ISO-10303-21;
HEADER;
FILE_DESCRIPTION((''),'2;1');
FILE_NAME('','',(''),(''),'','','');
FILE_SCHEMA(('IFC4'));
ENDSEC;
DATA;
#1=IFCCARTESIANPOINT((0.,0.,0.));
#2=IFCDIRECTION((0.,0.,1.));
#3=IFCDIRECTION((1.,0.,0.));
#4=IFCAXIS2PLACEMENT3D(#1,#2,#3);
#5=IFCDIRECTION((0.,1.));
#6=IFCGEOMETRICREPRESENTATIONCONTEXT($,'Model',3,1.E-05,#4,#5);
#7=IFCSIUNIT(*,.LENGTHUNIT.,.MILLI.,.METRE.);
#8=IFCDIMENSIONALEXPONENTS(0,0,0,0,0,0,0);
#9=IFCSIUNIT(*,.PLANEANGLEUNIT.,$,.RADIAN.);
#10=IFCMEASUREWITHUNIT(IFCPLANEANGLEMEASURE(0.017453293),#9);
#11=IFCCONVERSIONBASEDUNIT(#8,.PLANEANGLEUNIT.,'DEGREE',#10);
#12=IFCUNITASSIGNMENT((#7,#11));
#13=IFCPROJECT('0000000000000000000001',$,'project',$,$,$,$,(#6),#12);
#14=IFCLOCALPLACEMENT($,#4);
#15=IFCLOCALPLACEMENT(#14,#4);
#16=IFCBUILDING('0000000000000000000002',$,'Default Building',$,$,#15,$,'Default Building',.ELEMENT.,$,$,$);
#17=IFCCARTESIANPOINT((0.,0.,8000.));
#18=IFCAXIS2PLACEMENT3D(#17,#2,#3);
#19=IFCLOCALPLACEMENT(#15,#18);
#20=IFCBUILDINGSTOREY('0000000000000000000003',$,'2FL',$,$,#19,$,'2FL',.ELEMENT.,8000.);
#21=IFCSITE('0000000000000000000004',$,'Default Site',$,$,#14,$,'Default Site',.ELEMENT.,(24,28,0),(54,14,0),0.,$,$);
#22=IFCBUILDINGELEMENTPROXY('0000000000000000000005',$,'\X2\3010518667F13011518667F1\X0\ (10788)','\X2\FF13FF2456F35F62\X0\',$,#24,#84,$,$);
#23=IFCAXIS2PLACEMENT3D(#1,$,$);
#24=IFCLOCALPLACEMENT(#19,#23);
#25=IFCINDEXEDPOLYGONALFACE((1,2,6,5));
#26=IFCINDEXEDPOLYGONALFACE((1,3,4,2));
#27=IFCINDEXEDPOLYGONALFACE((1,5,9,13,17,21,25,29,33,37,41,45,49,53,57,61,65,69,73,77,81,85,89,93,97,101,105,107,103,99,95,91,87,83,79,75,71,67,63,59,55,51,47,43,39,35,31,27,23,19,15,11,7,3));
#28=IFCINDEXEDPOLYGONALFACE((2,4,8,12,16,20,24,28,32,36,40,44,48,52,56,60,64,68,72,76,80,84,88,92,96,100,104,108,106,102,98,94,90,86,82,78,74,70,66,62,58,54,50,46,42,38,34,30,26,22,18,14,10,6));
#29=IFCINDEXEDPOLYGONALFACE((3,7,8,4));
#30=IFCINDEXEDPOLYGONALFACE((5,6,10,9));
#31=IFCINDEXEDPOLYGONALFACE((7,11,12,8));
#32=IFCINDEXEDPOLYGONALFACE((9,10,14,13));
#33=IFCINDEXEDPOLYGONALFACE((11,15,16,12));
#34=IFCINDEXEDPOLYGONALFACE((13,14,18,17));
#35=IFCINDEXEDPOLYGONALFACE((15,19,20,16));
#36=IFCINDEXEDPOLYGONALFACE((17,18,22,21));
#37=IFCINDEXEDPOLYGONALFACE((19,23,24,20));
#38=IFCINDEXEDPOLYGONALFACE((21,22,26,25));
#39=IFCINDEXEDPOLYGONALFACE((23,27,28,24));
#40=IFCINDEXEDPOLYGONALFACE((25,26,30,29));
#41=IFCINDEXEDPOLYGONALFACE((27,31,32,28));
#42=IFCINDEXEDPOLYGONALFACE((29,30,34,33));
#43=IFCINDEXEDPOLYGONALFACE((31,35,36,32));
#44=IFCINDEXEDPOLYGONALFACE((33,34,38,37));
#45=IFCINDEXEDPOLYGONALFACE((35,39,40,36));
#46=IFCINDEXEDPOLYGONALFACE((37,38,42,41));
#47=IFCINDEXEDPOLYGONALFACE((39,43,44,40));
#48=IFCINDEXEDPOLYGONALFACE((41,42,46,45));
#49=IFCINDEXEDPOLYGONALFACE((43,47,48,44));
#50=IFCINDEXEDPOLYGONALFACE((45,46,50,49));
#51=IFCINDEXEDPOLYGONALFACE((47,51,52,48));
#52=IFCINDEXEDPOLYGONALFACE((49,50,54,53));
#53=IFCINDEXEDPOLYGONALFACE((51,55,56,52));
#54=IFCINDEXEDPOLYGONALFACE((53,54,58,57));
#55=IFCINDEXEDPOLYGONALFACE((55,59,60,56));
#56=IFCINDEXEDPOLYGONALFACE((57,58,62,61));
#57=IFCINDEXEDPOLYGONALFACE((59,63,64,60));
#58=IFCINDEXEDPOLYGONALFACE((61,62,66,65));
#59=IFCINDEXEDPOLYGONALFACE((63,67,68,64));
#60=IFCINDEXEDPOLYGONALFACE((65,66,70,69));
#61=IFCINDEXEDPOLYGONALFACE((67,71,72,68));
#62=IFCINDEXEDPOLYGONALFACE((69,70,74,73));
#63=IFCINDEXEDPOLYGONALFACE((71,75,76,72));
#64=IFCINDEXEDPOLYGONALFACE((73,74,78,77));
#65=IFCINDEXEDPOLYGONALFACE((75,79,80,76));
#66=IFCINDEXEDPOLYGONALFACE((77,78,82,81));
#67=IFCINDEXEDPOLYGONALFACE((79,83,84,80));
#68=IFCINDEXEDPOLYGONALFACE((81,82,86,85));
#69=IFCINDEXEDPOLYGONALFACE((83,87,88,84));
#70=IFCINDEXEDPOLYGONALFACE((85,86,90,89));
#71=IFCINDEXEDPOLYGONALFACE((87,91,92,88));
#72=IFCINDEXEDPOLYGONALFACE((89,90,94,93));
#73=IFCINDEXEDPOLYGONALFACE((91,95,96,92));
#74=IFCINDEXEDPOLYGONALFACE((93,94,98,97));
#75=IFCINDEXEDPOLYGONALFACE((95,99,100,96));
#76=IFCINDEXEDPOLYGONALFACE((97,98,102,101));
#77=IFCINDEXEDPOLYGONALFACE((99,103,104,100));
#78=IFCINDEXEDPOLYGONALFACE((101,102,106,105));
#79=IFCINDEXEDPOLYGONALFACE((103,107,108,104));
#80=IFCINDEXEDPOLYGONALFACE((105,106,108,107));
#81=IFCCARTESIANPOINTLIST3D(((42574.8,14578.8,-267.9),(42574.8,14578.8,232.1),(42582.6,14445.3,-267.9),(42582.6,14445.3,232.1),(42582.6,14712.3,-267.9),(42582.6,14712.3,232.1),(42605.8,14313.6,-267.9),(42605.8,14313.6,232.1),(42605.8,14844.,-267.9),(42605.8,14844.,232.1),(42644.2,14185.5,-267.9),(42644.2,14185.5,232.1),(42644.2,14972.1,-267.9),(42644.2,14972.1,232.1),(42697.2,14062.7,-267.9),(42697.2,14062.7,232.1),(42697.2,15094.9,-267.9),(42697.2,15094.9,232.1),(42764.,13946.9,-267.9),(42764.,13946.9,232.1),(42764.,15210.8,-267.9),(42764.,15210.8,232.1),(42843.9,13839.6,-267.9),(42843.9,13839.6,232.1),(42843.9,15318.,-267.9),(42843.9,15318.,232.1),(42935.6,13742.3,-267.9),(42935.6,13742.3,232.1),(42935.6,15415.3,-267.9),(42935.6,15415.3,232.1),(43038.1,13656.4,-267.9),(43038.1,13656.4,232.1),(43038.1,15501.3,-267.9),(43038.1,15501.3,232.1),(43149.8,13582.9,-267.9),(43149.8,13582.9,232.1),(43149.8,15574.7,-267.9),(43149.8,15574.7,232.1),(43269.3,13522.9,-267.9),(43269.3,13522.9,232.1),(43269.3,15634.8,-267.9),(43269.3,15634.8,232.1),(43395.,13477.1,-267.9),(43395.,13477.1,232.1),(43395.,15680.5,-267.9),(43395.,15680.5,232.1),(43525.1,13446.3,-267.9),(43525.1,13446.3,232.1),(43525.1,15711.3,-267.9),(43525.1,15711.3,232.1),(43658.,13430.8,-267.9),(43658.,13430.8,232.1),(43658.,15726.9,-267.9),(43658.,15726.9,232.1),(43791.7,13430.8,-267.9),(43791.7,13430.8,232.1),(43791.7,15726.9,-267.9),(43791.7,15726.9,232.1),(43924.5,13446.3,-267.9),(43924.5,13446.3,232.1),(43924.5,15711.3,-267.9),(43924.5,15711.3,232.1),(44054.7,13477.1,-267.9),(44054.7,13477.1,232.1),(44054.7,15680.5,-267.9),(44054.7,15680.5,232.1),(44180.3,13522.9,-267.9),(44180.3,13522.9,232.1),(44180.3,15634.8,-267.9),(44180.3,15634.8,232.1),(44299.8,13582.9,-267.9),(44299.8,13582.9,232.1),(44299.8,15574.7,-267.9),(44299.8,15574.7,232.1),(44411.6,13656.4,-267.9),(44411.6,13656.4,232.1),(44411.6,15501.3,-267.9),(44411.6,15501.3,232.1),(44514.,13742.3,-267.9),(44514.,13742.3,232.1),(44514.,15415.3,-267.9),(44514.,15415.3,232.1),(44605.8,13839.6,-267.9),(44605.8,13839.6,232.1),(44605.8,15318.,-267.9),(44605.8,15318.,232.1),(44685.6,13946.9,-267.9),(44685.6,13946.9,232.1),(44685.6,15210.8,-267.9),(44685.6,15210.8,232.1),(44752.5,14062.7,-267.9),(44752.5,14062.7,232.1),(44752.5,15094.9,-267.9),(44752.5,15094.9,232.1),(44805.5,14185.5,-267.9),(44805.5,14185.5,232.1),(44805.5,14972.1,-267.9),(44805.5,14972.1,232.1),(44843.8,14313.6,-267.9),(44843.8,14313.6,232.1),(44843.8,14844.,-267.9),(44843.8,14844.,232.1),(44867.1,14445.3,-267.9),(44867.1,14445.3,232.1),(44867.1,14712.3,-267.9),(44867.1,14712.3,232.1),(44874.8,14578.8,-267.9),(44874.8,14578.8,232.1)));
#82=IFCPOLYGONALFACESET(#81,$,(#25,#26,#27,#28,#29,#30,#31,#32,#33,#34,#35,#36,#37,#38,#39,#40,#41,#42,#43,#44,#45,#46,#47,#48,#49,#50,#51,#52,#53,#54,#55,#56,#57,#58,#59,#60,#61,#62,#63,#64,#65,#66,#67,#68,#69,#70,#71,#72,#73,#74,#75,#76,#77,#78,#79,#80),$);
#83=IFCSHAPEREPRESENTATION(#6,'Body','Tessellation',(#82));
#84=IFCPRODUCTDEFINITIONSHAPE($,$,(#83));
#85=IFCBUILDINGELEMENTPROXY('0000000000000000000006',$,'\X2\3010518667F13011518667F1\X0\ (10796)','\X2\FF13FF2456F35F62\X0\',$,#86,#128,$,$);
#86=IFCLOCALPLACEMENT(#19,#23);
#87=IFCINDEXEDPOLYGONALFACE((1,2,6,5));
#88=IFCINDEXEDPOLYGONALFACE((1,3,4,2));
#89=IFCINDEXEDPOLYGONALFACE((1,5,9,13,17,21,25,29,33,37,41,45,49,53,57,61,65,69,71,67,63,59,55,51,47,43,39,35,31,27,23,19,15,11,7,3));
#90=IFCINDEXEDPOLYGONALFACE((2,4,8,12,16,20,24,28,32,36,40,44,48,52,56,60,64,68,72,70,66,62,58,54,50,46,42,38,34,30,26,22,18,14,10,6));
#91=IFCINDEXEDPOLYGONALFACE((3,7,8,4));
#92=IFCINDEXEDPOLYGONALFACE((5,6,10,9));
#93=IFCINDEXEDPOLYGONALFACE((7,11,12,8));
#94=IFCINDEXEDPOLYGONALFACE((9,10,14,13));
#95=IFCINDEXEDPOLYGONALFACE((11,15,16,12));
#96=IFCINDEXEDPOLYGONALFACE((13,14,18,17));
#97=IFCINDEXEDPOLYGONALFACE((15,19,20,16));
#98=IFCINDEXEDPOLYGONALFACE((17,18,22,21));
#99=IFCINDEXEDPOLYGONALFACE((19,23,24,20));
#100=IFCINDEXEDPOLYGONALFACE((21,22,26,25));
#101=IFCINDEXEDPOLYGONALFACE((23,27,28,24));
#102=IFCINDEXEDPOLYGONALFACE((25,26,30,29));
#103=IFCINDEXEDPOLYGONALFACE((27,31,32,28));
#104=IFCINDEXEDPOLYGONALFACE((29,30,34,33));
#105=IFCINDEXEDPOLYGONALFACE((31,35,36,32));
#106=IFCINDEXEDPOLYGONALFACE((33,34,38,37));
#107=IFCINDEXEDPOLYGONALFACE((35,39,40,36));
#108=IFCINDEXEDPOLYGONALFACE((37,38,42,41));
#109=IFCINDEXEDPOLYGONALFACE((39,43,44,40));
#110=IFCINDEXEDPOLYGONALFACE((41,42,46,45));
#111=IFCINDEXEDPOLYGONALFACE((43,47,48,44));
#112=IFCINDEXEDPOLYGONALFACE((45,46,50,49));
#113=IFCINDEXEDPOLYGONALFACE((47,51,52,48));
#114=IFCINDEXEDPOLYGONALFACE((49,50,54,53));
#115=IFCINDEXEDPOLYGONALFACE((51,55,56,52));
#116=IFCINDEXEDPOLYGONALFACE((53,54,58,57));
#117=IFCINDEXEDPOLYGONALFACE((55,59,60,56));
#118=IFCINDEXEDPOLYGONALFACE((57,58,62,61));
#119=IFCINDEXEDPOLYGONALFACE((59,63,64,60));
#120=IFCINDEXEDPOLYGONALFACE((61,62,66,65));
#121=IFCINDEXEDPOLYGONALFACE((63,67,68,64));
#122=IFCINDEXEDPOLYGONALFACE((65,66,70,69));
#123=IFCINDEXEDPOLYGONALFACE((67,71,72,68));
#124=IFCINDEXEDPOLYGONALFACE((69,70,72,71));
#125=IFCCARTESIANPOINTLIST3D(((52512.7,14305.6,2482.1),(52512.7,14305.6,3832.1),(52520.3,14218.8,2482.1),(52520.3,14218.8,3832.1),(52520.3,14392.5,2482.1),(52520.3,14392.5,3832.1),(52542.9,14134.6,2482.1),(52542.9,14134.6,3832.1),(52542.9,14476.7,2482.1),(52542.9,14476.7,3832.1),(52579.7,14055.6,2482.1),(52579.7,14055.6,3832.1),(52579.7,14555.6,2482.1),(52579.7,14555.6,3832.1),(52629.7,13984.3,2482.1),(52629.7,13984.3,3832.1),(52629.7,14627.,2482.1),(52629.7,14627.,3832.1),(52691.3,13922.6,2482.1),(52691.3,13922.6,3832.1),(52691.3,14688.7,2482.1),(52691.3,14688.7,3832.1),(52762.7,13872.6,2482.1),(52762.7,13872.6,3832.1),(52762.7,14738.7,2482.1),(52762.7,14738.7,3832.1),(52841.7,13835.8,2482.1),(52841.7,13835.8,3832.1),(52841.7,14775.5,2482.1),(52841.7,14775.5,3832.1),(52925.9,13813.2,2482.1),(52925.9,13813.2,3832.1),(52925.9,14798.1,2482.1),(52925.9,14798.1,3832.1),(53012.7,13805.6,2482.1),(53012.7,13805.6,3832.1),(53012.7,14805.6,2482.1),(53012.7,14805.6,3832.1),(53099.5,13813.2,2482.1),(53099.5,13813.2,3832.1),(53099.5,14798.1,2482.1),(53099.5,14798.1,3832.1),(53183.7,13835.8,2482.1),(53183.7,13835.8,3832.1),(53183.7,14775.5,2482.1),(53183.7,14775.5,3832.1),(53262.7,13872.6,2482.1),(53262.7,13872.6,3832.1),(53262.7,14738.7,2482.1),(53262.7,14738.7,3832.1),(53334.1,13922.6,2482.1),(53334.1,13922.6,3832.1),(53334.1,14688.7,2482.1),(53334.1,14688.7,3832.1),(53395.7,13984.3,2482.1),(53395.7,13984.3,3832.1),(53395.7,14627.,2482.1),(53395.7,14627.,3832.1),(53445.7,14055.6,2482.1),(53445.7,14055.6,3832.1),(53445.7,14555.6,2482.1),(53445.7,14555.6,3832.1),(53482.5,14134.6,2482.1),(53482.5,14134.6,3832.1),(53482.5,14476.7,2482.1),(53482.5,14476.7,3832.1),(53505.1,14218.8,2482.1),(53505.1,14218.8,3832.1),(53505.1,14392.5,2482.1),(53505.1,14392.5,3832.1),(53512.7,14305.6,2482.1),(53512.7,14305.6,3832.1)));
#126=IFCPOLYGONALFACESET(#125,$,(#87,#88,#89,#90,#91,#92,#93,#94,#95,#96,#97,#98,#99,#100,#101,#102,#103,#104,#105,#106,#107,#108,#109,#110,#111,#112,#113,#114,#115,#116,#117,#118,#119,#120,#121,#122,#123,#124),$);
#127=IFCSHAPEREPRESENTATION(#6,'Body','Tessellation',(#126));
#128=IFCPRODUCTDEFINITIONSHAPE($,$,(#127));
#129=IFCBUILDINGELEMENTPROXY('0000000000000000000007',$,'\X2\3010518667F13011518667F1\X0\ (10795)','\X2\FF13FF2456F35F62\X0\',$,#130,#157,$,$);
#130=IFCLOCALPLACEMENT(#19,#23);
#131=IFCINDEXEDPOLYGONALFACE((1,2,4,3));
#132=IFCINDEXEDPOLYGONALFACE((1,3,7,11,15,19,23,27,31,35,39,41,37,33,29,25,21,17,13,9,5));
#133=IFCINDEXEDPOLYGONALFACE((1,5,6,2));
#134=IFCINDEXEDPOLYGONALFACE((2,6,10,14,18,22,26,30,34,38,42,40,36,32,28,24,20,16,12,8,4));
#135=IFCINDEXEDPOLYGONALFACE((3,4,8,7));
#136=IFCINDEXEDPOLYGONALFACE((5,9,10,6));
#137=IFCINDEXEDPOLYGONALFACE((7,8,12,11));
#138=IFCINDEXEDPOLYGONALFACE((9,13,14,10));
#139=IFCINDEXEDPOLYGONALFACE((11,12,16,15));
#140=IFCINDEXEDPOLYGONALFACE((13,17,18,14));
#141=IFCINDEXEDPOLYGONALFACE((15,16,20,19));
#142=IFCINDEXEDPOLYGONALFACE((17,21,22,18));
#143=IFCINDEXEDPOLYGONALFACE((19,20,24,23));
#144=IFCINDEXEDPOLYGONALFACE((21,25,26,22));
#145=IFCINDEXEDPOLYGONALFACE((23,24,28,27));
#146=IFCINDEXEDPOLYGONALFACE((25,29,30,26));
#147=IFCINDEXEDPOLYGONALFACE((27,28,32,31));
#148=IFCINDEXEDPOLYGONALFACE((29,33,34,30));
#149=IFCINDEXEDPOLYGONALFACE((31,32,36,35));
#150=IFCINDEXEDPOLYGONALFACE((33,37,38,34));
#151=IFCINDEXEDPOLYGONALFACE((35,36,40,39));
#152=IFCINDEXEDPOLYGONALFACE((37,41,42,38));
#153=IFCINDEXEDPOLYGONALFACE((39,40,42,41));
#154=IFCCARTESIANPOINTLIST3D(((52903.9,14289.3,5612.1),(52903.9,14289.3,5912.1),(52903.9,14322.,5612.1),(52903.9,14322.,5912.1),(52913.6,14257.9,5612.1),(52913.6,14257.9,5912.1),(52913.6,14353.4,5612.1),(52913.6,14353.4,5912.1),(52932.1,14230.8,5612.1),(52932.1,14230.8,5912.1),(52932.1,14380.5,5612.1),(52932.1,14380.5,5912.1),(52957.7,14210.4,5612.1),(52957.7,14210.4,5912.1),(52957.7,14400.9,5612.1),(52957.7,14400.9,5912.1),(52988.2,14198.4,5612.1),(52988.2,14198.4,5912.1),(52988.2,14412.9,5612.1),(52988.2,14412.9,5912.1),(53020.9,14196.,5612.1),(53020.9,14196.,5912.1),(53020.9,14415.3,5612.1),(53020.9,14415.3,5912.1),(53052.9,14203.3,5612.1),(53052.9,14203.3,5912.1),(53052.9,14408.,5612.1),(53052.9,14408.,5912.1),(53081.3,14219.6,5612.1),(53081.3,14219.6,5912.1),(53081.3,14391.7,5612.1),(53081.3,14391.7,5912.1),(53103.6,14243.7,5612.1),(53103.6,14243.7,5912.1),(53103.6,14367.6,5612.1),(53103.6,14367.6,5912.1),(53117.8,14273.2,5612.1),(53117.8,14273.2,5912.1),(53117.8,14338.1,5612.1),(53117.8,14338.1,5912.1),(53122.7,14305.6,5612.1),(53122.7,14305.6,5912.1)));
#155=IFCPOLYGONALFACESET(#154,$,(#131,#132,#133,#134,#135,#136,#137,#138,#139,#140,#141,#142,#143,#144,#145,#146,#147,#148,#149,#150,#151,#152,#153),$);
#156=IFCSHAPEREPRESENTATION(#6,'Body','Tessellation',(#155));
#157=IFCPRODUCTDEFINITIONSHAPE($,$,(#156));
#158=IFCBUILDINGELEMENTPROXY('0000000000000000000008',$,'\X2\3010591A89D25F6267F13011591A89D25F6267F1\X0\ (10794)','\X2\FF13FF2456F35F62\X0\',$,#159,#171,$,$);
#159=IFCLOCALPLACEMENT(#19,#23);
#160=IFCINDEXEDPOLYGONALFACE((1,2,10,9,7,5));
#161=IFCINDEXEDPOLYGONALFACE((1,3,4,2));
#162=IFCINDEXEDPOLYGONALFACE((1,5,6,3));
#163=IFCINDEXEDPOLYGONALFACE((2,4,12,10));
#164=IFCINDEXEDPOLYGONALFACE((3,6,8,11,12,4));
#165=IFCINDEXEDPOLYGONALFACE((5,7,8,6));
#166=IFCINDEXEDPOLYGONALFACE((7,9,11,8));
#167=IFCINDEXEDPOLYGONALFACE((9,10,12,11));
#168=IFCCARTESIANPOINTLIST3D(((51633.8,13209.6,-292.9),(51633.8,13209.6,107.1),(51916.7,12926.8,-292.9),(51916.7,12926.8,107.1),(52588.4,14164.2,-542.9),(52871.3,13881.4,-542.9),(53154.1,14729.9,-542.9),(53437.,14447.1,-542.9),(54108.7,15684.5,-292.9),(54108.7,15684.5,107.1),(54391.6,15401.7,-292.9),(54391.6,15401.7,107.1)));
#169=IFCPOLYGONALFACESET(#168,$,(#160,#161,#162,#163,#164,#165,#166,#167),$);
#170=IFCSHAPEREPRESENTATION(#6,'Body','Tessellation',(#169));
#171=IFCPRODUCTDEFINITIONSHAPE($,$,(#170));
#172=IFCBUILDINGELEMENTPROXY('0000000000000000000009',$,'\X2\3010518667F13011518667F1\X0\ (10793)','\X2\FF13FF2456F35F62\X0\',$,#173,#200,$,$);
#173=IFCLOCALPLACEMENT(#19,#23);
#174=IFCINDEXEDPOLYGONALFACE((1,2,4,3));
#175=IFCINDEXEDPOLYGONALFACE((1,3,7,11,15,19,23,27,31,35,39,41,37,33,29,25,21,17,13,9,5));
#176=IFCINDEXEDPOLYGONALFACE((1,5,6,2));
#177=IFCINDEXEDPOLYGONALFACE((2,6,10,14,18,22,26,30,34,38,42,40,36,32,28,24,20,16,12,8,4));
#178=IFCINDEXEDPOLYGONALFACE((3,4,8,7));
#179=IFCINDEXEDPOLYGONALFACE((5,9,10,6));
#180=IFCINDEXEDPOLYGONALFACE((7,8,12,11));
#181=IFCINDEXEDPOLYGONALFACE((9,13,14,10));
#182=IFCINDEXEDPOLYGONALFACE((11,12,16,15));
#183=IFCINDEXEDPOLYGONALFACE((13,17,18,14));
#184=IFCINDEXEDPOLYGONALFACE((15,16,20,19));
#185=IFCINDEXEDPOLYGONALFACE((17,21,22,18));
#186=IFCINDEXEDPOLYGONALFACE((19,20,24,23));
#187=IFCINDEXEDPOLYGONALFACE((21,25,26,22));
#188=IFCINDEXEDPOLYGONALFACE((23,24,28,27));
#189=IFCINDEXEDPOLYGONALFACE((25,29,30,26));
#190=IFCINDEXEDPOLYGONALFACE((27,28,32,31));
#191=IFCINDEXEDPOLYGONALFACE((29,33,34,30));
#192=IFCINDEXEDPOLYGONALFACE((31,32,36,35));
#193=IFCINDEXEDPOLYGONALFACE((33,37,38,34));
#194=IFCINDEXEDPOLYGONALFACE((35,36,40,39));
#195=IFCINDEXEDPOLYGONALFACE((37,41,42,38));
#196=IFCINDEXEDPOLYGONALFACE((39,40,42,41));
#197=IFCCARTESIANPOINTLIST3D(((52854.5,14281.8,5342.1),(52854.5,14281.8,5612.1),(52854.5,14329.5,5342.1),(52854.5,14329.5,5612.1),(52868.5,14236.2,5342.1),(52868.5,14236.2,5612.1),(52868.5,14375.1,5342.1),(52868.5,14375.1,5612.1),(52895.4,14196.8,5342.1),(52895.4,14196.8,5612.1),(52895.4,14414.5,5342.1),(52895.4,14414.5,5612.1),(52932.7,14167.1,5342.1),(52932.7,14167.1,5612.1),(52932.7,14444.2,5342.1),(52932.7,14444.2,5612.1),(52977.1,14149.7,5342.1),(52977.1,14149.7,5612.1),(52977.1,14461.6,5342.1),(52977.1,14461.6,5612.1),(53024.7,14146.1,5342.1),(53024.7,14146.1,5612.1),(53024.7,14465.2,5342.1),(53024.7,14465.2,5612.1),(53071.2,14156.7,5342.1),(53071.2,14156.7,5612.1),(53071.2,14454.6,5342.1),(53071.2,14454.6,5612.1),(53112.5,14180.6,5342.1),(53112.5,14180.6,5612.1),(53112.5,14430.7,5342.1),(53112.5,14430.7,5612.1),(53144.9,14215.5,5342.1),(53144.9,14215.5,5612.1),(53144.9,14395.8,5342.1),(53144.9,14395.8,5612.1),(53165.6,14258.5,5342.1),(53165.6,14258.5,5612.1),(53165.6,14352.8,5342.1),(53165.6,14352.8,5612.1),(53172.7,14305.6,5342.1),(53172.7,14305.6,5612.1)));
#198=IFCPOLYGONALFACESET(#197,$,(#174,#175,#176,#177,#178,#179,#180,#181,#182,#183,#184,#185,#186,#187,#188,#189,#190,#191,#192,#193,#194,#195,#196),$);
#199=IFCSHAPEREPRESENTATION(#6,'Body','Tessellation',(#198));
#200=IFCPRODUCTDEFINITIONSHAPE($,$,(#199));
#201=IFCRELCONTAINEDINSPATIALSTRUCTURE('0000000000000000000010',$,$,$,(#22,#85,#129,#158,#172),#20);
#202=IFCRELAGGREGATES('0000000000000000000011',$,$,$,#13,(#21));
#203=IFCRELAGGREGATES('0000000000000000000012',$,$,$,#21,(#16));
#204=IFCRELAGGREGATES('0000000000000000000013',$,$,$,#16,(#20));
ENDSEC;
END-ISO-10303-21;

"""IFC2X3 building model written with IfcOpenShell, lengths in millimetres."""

from ifc_helpers import new_model, entity, si_unit, converted_unit, direction, frame, origin_with_axes, origin_2d_with_axis, place, context, project, spatial, polyline, circle, outline, extrude, source, transform, mapped, element, save


model = new_model("IFC2X3")

# Units and contexts
model_context = context("Model", 3, precision=1e-05, world=origin_with_axes(), true_north=direction((0.0, 1.0)))
ifc_project = project(units=[si_unit("LENGTHUNIT", "METRE", prefix="MILLI"), converted_unit("PLANEANGLEUNIT", "DEGREE", entity("IfcPlaneAngleMeasure", 0.017453293), si_unit("PLANEANGLEUNIT", "RADIAN"), dimensions=[0, 0, 0, 0, 0, 0, 0])], contexts=[model_context])

# Site, building, storey
site_placement = place(None, origin_with_axes())
site = spatial("IfcSite", under=ifc_project, at=site_placement, Name="Default Site", LongName="Default Site", CompositionType="ELEMENT", RefLatitude=(24, 28, 0), RefLongitude=(54, 14, 0), RefElevation=0.0)
building_placement = place(site_placement, origin_with_axes())
building = spatial("IfcBuilding", under=site, at=building_placement, Name="Default Building", LongName="Default Building", CompositionType="ELEMENT")
storey_placement = place(building_placement, frame((0.0, 0.0, 8000.0), z_axis=(0.0, 0.0, 1.0), x_axis=(1.0, 0.0, 0.0)))
storey = spatial("IfcBuildingStorey", under=building, at=storey_placement, Name="2FL", LongName="2FL", CompositionType="ELEMENT", Elevation=8000.0)

# Building element proxies
shared_shape_1 = source(origin_with_axes(), model_context, "Body", "SweptSolid", [
    extrude(circle(Radius=1150.0, at=origin_2d_with_axis()), origin_with_axes(), (0.0, 0.0, 1.0), 500.0),
])
proxy_1_placement = place(storey_placement, frame((43724.8, 14578.8, -267.9), z_axis=(0.0, 0.0, 1.0), x_axis=(1.0, 0.0, 0.0)))
element("IfcBuildingElementProxy", 1, at=proxy_1_placement, inside=storey, Name="【円柱】円柱 (10788)", Description="３Ｄ図形", context=model_context, shape_type="MappedRepresentation", body=[
    mapped(shared_shape_1, transform((0.0, 0.0, 0.0))),
])
shared_shape_2 = source(origin_with_axes(), model_context, "Body", "SweptSolid", [
    extrude(circle(Radius=500.0, at=origin_2d_with_axis()), origin_with_axes(), (0.0, 0.0, 1.0), 1350.0),
])
proxy_2_placement = place(storey_placement, frame((53012.7, 14305.6, 2482.1), z_axis=(0.0, 0.0, 1.0), x_axis=(1.0, 0.0, 0.0)))
element("IfcBuildingElementProxy", 2, at=proxy_2_placement, inside=storey, Name="【円柱】円柱 (10796)", Description="３Ｄ図形", context=model_context, shape_type="MappedRepresentation", body=[
    mapped(shared_shape_2, transform((0.0, 0.0, 0.0))),
])
shared_shape_3 = source(origin_with_axes(), model_context, "Body", "SweptSolid", [
    extrude(circle(Radius=110.0, at=origin_2d_with_axis()), origin_with_axes(), (0.0, 0.0, 1.0), 300.0),
])
proxy_3_placement = place(storey_placement, frame((53012.7, 14305.6, 5612.1), z_axis=(0.0, 0.0, 1.0), x_axis=(1.0, 0.0, 0.0)))
element("IfcBuildingElementProxy", 3, at=proxy_3_placement, inside=storey, Name="【円柱】円柱 (10795)", Description="３Ｄ図形", context=model_context, shape_type="MappedRepresentation", body=[
    mapped(shared_shape_3, transform((0.0, 0.0, 0.0))),
])
shared_shape_4 = source(origin_with_axes(), model_context, "Body", "SweptSolid", [
    extrude(outline(polyline([(-1750.0, 325.0), (-1750.0, -75.0), (-400.0, -325.0), (400.0, -325.0), (1750.0, -75.0), (1750.0, 325.0), (-1750.0, 325.0)])), frame((0.0, 0.0, 0.0), z_axis=(0.0, 0.0, 1.0), x_axis=(1.0, 0.0, 0.0)), (0.0, 0.0, 1.0), 400.0),
])
proxy_4_placement = place(storey_placement, frame((52871.3, 14447.1, -217.9), z_axis=(0.707107, -0.707107, 0.0), x_axis=(0.707107, 0.707107, 0.0)))
element("IfcBuildingElementProxy", 4, at=proxy_4_placement, inside=storey, Name="【多角形柱】多角形柱 (10794)", Description="３Ｄ図形", context=model_context, shape_type="MappedRepresentation", body=[
    mapped(shared_shape_4, transform((0.0, 0.0, 0.0))),
])
shared_shape_5 = source(origin_with_axes(), model_context, "Body", "SweptSolid", [
    extrude(circle(Radius=160.0, at=origin_2d_with_axis()), origin_with_axes(), (0.0, 0.0, 1.0), 270.0),
])
proxy_5_placement = place(storey_placement, frame((53012.7, 14305.6, 5342.1), z_axis=(0.0, 0.0, 1.0), x_axis=(1.0, 0.0, 0.0)))
element("IfcBuildingElementProxy", 5, at=proxy_5_placement, inside=storey, Name="【円柱】円柱 (10793)", Description="３Ｄ図形", context=model_context, shape_type="MappedRepresentation", body=[
    mapped(shared_shape_5, transform((0.0, 0.0, 0.0))),
])

save(model, "model.ifc")
